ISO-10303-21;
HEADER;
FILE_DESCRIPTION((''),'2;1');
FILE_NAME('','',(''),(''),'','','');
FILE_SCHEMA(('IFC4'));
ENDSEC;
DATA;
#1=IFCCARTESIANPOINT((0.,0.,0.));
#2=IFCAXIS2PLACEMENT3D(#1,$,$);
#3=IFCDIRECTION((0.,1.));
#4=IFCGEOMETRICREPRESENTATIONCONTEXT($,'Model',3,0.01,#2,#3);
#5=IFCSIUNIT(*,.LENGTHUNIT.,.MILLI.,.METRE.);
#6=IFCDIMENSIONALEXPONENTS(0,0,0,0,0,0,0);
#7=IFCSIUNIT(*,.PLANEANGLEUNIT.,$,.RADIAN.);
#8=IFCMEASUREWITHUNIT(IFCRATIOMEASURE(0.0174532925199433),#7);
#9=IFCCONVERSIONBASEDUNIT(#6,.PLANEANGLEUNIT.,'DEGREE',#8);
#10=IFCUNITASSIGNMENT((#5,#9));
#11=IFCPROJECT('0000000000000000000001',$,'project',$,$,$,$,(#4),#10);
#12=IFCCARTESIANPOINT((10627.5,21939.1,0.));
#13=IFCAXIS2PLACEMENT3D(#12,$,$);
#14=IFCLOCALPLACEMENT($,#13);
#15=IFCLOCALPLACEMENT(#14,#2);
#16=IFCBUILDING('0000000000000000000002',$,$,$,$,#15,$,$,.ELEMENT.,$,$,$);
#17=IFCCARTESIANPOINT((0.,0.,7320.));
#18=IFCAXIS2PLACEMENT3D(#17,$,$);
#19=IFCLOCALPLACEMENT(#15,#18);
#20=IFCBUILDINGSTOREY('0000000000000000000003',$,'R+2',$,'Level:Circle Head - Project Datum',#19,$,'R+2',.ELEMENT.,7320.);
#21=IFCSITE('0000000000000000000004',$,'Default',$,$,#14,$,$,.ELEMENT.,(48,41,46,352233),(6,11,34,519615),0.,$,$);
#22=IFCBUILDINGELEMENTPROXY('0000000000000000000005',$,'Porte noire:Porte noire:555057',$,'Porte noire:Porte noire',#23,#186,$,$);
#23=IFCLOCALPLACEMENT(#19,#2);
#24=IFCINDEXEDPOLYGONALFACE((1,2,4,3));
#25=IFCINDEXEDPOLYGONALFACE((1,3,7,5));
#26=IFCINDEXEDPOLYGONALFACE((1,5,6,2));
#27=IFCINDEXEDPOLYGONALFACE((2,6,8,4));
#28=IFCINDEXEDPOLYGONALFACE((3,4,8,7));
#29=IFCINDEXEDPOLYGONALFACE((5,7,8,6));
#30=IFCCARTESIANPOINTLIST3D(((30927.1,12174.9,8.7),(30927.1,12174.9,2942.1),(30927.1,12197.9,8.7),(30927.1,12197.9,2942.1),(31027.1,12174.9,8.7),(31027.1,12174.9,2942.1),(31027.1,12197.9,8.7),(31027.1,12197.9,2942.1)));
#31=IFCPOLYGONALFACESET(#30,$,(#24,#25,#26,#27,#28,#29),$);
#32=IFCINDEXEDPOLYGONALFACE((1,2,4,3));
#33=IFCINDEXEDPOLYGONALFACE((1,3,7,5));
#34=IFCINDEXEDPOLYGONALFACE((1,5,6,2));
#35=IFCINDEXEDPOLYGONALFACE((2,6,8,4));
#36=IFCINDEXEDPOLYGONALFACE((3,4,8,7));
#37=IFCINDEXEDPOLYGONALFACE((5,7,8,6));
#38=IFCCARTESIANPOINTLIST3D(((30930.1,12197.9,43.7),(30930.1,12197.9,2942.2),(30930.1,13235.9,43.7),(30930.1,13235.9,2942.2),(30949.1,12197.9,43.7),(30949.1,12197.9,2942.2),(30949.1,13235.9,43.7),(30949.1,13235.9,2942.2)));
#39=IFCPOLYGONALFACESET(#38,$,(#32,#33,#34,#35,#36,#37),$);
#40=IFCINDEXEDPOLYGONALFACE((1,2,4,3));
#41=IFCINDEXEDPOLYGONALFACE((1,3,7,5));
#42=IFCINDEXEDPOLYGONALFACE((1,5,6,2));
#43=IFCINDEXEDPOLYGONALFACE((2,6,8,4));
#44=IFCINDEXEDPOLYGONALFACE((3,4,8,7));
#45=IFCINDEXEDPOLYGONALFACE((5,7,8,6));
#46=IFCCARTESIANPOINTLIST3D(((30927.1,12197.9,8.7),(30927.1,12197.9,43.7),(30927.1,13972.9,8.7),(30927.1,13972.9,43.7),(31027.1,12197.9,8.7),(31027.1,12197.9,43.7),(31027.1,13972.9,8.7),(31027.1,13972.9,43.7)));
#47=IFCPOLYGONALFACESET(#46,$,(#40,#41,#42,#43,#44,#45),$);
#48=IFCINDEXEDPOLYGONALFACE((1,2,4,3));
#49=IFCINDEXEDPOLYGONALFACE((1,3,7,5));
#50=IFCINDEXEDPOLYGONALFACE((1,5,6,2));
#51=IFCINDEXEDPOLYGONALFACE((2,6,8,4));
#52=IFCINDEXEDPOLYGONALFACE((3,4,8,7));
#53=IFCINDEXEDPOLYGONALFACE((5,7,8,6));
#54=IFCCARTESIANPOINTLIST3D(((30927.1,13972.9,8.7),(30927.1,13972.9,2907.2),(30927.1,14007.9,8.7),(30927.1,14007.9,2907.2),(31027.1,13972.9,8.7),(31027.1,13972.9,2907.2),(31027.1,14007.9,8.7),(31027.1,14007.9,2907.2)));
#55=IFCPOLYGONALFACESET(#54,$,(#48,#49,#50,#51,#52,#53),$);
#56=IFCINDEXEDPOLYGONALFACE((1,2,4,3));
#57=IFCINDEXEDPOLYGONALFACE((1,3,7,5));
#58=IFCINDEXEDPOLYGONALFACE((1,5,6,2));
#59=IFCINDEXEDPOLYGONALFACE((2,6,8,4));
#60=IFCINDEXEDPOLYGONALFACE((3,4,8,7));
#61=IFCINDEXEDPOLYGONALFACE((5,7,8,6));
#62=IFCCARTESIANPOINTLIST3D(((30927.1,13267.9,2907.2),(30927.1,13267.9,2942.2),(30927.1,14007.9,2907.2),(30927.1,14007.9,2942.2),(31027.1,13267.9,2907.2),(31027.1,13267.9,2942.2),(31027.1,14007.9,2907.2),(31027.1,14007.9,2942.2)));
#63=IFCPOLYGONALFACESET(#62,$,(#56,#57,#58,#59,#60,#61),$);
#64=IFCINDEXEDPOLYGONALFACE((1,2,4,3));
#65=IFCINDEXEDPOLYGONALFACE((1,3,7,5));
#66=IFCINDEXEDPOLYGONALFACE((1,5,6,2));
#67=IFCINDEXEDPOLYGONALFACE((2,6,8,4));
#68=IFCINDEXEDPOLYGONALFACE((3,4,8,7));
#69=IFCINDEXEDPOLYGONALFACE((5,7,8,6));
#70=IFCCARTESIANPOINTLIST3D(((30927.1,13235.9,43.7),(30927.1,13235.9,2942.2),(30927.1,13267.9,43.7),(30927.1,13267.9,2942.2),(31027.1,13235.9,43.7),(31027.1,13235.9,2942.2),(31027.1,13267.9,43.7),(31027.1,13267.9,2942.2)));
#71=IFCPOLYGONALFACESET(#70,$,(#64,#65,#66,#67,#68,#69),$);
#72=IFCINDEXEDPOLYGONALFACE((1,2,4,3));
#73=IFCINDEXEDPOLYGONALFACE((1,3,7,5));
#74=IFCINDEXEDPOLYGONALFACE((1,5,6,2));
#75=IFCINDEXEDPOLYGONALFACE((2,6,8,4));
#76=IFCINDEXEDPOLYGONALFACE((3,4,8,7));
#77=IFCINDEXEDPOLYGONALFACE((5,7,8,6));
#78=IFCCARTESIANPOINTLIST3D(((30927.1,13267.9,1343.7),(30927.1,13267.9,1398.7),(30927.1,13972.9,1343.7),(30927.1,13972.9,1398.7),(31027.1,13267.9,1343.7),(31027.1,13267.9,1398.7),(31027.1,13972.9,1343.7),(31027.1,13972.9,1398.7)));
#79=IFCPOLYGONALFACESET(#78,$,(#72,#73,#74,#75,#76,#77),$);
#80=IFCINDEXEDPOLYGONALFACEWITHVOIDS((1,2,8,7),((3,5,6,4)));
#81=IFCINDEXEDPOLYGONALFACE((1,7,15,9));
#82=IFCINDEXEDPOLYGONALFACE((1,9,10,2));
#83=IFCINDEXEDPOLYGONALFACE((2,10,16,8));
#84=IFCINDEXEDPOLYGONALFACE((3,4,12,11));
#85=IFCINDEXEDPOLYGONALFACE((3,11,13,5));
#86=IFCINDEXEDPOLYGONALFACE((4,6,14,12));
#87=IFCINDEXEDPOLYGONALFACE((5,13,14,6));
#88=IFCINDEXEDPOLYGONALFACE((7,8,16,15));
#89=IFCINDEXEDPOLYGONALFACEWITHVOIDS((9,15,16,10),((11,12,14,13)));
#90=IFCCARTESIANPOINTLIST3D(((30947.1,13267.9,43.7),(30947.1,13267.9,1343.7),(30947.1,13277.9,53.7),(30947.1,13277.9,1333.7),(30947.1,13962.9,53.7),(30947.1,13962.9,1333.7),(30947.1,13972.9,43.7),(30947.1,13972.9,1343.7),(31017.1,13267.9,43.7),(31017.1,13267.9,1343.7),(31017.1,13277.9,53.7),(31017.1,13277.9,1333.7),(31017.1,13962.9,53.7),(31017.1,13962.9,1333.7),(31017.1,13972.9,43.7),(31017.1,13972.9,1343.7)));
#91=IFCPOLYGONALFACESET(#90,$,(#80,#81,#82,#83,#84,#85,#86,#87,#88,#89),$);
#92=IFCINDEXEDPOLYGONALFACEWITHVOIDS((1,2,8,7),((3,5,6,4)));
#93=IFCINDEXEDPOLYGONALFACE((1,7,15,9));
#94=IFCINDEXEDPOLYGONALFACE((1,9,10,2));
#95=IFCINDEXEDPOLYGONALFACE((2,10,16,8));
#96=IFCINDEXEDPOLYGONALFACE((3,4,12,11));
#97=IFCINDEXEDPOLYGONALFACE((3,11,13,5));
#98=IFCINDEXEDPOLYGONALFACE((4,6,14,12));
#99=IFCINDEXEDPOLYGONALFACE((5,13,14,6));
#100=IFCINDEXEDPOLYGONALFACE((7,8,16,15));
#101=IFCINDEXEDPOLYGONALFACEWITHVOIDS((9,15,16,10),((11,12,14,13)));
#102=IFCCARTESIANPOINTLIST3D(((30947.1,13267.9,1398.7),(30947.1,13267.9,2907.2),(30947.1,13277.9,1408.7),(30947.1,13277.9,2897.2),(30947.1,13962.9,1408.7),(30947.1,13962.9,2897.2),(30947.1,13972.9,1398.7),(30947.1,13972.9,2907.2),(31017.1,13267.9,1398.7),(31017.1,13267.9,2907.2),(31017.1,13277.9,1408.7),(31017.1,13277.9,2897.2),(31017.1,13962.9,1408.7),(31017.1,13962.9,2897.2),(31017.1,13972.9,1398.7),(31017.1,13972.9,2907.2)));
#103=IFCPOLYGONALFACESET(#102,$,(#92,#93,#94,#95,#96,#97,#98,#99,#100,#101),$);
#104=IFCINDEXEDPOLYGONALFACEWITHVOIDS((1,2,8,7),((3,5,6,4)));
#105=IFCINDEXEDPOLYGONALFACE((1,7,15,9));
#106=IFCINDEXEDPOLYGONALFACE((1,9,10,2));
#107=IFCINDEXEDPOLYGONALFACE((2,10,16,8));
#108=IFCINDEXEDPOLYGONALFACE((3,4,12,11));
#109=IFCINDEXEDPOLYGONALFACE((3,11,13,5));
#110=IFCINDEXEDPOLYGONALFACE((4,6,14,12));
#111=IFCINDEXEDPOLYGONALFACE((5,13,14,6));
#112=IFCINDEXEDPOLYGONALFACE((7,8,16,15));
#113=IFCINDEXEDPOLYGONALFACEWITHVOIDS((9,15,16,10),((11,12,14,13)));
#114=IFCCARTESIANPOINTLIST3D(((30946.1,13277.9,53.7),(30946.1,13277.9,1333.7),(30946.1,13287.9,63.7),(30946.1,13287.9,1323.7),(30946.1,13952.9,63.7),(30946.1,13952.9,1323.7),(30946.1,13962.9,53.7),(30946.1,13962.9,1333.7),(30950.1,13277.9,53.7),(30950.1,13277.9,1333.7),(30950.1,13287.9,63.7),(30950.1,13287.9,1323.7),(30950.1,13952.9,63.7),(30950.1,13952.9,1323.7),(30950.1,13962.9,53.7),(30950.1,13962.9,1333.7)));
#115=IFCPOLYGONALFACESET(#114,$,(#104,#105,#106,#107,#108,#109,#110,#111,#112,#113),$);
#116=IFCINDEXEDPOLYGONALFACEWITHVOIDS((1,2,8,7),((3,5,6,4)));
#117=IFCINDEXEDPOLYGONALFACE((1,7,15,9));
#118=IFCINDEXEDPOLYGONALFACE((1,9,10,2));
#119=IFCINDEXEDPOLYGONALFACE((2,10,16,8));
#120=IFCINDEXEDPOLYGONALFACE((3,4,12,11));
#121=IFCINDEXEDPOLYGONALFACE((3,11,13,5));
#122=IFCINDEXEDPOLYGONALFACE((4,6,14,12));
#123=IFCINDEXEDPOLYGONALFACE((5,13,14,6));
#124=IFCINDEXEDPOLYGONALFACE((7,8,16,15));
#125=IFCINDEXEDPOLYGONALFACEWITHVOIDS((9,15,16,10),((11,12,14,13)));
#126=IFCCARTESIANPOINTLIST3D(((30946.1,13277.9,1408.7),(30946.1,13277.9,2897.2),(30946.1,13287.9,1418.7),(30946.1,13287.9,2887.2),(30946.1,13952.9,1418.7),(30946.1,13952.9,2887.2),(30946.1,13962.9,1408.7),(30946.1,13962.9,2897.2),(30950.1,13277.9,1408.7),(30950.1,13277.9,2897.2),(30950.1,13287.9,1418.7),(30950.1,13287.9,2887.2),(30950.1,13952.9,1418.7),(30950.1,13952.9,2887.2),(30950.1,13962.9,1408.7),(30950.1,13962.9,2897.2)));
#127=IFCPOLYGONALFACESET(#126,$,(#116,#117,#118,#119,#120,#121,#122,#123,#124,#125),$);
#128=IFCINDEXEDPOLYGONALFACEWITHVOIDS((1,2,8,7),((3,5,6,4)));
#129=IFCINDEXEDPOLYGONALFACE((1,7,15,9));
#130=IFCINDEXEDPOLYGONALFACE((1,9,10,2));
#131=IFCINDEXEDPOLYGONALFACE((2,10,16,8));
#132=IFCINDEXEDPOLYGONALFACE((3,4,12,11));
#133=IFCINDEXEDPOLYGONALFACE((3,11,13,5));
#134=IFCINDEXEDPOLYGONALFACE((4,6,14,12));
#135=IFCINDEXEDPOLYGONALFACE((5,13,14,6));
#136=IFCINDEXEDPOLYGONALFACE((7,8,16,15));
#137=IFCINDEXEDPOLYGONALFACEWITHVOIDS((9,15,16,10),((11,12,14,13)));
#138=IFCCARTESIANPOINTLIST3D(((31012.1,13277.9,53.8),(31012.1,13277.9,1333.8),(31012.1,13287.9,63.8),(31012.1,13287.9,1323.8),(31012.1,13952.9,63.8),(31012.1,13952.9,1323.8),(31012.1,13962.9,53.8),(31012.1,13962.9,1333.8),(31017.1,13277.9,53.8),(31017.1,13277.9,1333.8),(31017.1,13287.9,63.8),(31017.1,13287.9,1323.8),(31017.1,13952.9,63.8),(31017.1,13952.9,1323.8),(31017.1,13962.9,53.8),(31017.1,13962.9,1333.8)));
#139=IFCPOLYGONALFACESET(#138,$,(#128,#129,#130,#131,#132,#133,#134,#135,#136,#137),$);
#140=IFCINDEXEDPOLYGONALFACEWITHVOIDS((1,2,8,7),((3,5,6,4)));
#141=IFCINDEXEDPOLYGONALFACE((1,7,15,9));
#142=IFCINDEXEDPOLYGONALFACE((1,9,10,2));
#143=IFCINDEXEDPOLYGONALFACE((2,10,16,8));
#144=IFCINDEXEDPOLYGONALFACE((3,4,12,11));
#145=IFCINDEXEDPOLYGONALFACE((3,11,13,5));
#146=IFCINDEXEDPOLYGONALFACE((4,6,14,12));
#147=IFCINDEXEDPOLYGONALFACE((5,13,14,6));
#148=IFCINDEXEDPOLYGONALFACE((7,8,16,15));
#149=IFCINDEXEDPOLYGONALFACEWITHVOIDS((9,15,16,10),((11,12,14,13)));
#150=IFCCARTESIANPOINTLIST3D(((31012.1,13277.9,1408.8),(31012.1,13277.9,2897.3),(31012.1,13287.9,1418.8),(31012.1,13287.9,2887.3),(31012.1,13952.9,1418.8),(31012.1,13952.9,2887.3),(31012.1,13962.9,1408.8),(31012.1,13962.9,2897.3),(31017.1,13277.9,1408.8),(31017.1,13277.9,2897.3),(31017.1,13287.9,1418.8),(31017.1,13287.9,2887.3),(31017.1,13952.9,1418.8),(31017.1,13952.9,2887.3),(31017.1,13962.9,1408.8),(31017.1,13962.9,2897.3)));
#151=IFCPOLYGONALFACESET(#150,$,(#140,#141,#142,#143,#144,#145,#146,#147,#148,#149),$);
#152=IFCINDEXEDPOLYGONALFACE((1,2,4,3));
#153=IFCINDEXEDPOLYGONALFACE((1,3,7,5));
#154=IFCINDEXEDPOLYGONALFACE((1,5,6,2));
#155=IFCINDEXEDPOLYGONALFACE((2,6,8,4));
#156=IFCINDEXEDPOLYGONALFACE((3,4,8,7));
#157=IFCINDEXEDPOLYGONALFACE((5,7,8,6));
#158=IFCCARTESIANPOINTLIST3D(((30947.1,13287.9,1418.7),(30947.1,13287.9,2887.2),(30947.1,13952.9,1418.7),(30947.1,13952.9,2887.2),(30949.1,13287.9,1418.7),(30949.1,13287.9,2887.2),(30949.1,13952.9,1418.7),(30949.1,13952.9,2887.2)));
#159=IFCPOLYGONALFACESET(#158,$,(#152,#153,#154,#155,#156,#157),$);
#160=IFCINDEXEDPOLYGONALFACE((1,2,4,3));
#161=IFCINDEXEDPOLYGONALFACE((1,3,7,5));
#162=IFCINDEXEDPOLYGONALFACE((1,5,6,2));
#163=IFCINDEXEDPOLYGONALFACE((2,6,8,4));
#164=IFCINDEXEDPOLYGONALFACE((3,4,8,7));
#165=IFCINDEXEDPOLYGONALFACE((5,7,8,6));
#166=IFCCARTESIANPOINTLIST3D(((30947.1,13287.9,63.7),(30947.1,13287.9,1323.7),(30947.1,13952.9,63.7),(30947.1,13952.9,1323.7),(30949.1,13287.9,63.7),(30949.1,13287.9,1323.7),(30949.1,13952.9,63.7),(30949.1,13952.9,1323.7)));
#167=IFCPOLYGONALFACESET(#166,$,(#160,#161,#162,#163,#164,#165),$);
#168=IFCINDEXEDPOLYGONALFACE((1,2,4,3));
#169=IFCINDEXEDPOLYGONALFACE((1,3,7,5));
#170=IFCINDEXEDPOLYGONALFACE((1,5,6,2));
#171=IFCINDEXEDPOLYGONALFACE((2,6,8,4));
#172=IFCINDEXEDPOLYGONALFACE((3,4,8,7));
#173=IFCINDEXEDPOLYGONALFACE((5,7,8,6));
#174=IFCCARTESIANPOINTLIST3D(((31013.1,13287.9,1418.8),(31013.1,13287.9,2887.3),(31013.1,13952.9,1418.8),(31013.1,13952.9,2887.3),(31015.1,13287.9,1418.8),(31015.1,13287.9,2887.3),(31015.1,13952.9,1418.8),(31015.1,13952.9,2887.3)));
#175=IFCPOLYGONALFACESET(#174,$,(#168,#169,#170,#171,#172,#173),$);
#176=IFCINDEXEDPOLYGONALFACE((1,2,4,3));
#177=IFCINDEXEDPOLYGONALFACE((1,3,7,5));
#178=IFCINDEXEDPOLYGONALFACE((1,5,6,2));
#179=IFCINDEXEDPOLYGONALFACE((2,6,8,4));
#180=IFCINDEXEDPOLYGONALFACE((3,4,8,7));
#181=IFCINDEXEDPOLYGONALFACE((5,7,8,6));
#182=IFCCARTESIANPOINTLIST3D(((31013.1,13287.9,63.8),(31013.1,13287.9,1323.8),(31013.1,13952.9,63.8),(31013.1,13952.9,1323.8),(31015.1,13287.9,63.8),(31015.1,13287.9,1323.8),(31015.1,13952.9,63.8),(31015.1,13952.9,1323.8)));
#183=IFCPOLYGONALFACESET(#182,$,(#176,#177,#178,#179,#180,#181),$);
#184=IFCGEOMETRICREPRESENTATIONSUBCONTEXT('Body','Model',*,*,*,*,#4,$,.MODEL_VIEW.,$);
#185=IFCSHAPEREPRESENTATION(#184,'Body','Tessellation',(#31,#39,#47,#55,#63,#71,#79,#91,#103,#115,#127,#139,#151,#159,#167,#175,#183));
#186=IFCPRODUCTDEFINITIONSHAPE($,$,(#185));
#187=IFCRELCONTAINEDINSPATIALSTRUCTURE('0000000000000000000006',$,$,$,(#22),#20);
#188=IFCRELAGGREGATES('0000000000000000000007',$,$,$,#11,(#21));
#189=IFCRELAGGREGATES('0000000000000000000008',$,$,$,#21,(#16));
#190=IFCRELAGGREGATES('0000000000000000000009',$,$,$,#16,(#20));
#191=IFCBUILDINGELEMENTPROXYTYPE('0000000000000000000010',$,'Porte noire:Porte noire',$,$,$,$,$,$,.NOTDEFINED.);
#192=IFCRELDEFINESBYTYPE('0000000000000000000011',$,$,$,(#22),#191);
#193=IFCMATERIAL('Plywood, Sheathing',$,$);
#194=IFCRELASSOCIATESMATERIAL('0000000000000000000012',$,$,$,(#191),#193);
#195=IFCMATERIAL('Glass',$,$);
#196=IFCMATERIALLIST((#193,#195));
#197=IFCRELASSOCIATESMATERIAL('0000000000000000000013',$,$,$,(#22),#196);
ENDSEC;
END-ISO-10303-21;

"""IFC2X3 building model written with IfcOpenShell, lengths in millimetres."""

from ifc_helpers import new_model, entity, si_unit, converted_unit, direction, frame, frame_2d, origin, origin_2d_with_axis, place, context, subcontext, project, spatial, polyline, rectangle, outline, extrude, source, transform, mapped, material, material_list, type_object, type_shapes, element, save


model = new_model("IFC2X3")

# Units and contexts
model_context = context("Model", 3, precision=0.01, world=origin(), true_north=direction((0.0, 1.0)))
body_context = subcontext(model_context, "Body", "Model", "MODEL_VIEW")
ifc_project = project(units=[si_unit("LENGTHUNIT", "METRE", prefix="MILLI"), converted_unit("PLANEANGLEUNIT", "DEGREE", entity("IfcRatioMeasure", 0.0174532925199433), si_unit("PLANEANGLEUNIT", "RADIAN"), dimensions=[0, 0, 0, 0, 0, 0, 0])], contexts=[model_context])

# Site, building, storey
site_placement = place(None, frame((10627.5, 21939.1, 0.0)))
site = spatial("IfcSite", under=ifc_project, at=site_placement, Name="Default", CompositionType="ELEMENT", RefLatitude=(48, 41, 46, 352233), RefLongitude=(6, 11, 34, 519615), RefElevation=0.0)
building_placement = place(site_placement, origin())
building = spatial("IfcBuilding", under=site, at=building_placement, CompositionType="ELEMENT")
storey_placement = place(building_placement, frame((0.0, 0.0, 7320.0)))
storey = spatial("IfcBuildingStorey", under=building, at=storey_placement, Name="R+2", ObjectType="Level:Circle Head - Project Datum", LongName="R+2", CompositionType="ELEMENT", Elevation=7320.0)

# Building element proxy
ifc_material_1 = material(Name="Glass")
ifc_material_2 = material(Name="Plywood, Sheathing")
building_element_proxy_type_1 = type_object("IfcBuildingElementProxyType", Name="Porte noire:Porte noire", PredefinedType="NOTDEFINED", material=ifc_material_2)
shared_shape_1 = source(origin(), body_context, "Body", "SweptSolid", [
    extrude(rectangle(XDim=23.0, YDim=100.0, at=frame_2d((0.0, 0.0), x_axis=(1.0, 0.0))), frame((-950.9, 50.0, 8.7), z_axis=(0.0, 0.0, 1.0), x_axis=(-1.0, 0.0, 0.0)), (0.0, 0.0, 1.0), 2933.3),
    extrude(rectangle(XDim=1038.0, YDim=19.0, at=frame_2d((0.0, 0.0), x_axis=(1.0, 0.0))), frame((-420.4, 87.5, 43.7), z_axis=(0.0, 0.0, 1.0), x_axis=(-1.0, 0.0, 0.0)), (0.0, 0.0, 1.0), 2898.5),
    extrude(rectangle(XDim=1775.0, YDim=100.0, at=origin_2d_with_axis()), frame((-51.9, 50.0, 8.7), z_axis=(0.0, 0.0, 1.0), x_axis=(-1.0, 0.0, 0.0)), (0.0, 0.0, 1.0), 35.0),
    extrude(rectangle(XDim=35.0, YDim=100.0, at=origin_2d_with_axis()), frame((853.1, 50.0, 8.7), z_axis=(0.0, 0.0, 1.0), x_axis=(-1.0, 0.0, 0.0)), (0.0, 0.0, 1.0), 2898.5),
    extrude(rectangle(XDim=740.0, YDim=100.0, at=origin_2d_with_axis()), frame((500.6, 50.0, 2907.2), z_axis=(0.0, 0.0, 1.0), x_axis=(-1.0, 0.0, 0.0)), (0.0, 0.0, 1.0), 35.0),
    extrude(rectangle(XDim=32.0, YDim=100.0, at=origin_2d_with_axis()), frame((114.6, 50.0, 43.7), z_axis=(0.0, 0.0, 1.0), x_axis=(-1.0, 0.0, 0.0)), (0.0, 0.0, 1.0), 2898.5),
    extrude(rectangle(XDim=705.0, YDim=100.0, at=origin_2d_with_axis()), frame((483.1, 50.0, 1343.7), z_axis=(0.0, 0.0, 1.0), x_axis=(-1.0, 0.0, 0.0)), (0.0, 0.0, 1.0), 55.0),
    extrude(outline(polyline([(-352.5, -650.0), (352.5, -650.0), (352.5, 650.0), (-352.5, 650.0), (-352.5, -650.0)]), holes=[polyline([(342.5, 640.0), (342.5, -640.0), (-342.5, -640.0), (-342.5, 640.0), (342.5, 640.0)])]), frame((483.1, 10.0, 693.7), z_axis=(0.0, 1.0, 0.0), x_axis=(1.0, 0.0, 0.0)), (0.0, 0.0, 1.0), 70.0),
    extrude(outline(polyline([(-754.2, -352.5), (754.2, -352.5), (754.2, 352.5), (-754.2, 352.5), (-754.2, -352.5)]), holes=[polyline([(744.2, 342.5), (744.2, -342.5), (-744.2, -342.5), (-744.2, 342.5), (744.2, 342.5)])]), frame((483.1, 10.0, 2153.0), z_axis=(0.0, 1.0, 0.0), x_axis=(0.0, 0.0, 1.0)), (0.0, 0.0, 1.0), 70.0),
    extrude(outline(polyline([(-640.0, -342.5), (640.0, -342.5), (640.0, 342.5), (-640.0, 342.5), (-640.0, -342.5)]), holes=[polyline([(630.0, 332.5), (630.0, -332.5), (-630.0, -332.5), (-630.0, 332.5), (630.0, 332.5)])]), frame((483.1, 77.0, 693.7), z_axis=(0.0, 1.0, 0.0), x_axis=(0.0, 0.0, 1.0)), (0.0, 0.0, 1.0), 4.0),
    extrude(outline(polyline([(-744.2, -342.5), (744.2, -342.5), (744.2, 342.5), (-744.2, 342.5), (-744.2, -342.5)]), holes=[polyline([(734.2, 332.5), (734.2, -332.5), (-734.2, -332.5), (-734.2, 332.5), (734.2, 332.5)])]), frame((483.1, 77.0, 2153.0), z_axis=(0.0, 1.0, 0.0), x_axis=(0.0, 0.0, 1.0)), (0.0, 0.0, 1.0), 4.0),
    extrude(outline(polyline([(-640.0, -342.5), (640.0, -342.5), (640.0, 342.5), (-640.0, 342.5), (-640.0, -342.5)]), holes=[polyline([(630.0, 332.5), (630.0, -332.5), (-630.0, -332.5), (-630.0, 332.5), (630.0, 332.5)])]), frame((483.1, 10.0, 693.8), z_axis=(0.0, 1.0, 0.0), x_axis=(0.0, 0.0, 1.0)), (0.0, 0.0, 1.0), 5.0),
    extrude(outline(polyline([(-744.2, -342.5), (744.2, -342.5), (744.2, 342.5), (-744.2, 342.5), (-744.2, -342.5)]), holes=[polyline([(734.2, 332.5), (734.2, -332.5), (-734.2, -332.5), (-734.2, 332.5), (734.2, 332.5)])]), frame((483.1, 10.0, 2153.0), z_axis=(0.0, 1.0, 0.0), x_axis=(0.0, 0.0, 1.0)), (0.0, 0.0, 1.0), 5.0),
    extrude(rectangle(XDim=665.0, YDim=2.0, at=frame_2d((0.0, 0.0), x_axis=(1.0, 0.0))), frame((483.1, 79.0, 1418.7), z_axis=(0.0, 0.0, 1.0), x_axis=(-1.0, 0.0, 0.0)), (0.0, 0.0, 1.0), 1468.5),
    extrude(rectangle(XDim=665.0, YDim=2.0, at=frame_2d((0.0, 0.0), x_axis=(1.0, 0.0))), frame((483.1, 79.0, 63.7), z_axis=(0.0, 0.0, 1.0), x_axis=(-1.0, 0.0, 0.0)), (0.0, 0.0, 1.0), 1260.0),
    extrude(rectangle(XDim=665.0, YDim=2.0, at=frame_2d((0.0, 0.0), x_axis=(1.0, 0.0))), frame((483.1, 13.0, 1418.8), z_axis=(0.0, 0.0, 1.0), x_axis=(-1.0, 0.0, 0.0)), (0.0, 0.0, 1.0), 1468.5),
    extrude(rectangle(XDim=665.0, YDim=2.0, at=frame_2d((0.0, 0.0), x_axis=(1.0, 0.0))), frame((483.1, 13.0, 63.8), z_axis=(0.0, 0.0, 1.0), x_axis=(-1.0, 0.0, 0.0)), (0.0, 0.0, 1.0), 1260.0),
])
type_shapes(building_element_proxy_type_1, [shared_shape_1])
ifc_material_list_1 = material_list([ifc_material_2, ifc_material_1])
proxy_1_placement = place(storey_placement, frame((31027.1, 13137.3, 0.0), z_axis=(0.0, 0.0, 1.0), x_axis=(0.0, 1.0, 0.0)))
element("IfcBuildingElementProxy", 1, at=proxy_1_placement, inside=storey, type_object=building_element_proxy_type_1, material=ifc_material_list_1, Name="Porte noire:Porte noire:555057", ObjectType="Porte noire:Porte noire", context=body_context, shape_type="MappedRepresentation", body=[
    mapped(shared_shape_1, transform((0.0, 0.0, 0.0), scale=1.0)),
])

save(model, "model.ifc")
